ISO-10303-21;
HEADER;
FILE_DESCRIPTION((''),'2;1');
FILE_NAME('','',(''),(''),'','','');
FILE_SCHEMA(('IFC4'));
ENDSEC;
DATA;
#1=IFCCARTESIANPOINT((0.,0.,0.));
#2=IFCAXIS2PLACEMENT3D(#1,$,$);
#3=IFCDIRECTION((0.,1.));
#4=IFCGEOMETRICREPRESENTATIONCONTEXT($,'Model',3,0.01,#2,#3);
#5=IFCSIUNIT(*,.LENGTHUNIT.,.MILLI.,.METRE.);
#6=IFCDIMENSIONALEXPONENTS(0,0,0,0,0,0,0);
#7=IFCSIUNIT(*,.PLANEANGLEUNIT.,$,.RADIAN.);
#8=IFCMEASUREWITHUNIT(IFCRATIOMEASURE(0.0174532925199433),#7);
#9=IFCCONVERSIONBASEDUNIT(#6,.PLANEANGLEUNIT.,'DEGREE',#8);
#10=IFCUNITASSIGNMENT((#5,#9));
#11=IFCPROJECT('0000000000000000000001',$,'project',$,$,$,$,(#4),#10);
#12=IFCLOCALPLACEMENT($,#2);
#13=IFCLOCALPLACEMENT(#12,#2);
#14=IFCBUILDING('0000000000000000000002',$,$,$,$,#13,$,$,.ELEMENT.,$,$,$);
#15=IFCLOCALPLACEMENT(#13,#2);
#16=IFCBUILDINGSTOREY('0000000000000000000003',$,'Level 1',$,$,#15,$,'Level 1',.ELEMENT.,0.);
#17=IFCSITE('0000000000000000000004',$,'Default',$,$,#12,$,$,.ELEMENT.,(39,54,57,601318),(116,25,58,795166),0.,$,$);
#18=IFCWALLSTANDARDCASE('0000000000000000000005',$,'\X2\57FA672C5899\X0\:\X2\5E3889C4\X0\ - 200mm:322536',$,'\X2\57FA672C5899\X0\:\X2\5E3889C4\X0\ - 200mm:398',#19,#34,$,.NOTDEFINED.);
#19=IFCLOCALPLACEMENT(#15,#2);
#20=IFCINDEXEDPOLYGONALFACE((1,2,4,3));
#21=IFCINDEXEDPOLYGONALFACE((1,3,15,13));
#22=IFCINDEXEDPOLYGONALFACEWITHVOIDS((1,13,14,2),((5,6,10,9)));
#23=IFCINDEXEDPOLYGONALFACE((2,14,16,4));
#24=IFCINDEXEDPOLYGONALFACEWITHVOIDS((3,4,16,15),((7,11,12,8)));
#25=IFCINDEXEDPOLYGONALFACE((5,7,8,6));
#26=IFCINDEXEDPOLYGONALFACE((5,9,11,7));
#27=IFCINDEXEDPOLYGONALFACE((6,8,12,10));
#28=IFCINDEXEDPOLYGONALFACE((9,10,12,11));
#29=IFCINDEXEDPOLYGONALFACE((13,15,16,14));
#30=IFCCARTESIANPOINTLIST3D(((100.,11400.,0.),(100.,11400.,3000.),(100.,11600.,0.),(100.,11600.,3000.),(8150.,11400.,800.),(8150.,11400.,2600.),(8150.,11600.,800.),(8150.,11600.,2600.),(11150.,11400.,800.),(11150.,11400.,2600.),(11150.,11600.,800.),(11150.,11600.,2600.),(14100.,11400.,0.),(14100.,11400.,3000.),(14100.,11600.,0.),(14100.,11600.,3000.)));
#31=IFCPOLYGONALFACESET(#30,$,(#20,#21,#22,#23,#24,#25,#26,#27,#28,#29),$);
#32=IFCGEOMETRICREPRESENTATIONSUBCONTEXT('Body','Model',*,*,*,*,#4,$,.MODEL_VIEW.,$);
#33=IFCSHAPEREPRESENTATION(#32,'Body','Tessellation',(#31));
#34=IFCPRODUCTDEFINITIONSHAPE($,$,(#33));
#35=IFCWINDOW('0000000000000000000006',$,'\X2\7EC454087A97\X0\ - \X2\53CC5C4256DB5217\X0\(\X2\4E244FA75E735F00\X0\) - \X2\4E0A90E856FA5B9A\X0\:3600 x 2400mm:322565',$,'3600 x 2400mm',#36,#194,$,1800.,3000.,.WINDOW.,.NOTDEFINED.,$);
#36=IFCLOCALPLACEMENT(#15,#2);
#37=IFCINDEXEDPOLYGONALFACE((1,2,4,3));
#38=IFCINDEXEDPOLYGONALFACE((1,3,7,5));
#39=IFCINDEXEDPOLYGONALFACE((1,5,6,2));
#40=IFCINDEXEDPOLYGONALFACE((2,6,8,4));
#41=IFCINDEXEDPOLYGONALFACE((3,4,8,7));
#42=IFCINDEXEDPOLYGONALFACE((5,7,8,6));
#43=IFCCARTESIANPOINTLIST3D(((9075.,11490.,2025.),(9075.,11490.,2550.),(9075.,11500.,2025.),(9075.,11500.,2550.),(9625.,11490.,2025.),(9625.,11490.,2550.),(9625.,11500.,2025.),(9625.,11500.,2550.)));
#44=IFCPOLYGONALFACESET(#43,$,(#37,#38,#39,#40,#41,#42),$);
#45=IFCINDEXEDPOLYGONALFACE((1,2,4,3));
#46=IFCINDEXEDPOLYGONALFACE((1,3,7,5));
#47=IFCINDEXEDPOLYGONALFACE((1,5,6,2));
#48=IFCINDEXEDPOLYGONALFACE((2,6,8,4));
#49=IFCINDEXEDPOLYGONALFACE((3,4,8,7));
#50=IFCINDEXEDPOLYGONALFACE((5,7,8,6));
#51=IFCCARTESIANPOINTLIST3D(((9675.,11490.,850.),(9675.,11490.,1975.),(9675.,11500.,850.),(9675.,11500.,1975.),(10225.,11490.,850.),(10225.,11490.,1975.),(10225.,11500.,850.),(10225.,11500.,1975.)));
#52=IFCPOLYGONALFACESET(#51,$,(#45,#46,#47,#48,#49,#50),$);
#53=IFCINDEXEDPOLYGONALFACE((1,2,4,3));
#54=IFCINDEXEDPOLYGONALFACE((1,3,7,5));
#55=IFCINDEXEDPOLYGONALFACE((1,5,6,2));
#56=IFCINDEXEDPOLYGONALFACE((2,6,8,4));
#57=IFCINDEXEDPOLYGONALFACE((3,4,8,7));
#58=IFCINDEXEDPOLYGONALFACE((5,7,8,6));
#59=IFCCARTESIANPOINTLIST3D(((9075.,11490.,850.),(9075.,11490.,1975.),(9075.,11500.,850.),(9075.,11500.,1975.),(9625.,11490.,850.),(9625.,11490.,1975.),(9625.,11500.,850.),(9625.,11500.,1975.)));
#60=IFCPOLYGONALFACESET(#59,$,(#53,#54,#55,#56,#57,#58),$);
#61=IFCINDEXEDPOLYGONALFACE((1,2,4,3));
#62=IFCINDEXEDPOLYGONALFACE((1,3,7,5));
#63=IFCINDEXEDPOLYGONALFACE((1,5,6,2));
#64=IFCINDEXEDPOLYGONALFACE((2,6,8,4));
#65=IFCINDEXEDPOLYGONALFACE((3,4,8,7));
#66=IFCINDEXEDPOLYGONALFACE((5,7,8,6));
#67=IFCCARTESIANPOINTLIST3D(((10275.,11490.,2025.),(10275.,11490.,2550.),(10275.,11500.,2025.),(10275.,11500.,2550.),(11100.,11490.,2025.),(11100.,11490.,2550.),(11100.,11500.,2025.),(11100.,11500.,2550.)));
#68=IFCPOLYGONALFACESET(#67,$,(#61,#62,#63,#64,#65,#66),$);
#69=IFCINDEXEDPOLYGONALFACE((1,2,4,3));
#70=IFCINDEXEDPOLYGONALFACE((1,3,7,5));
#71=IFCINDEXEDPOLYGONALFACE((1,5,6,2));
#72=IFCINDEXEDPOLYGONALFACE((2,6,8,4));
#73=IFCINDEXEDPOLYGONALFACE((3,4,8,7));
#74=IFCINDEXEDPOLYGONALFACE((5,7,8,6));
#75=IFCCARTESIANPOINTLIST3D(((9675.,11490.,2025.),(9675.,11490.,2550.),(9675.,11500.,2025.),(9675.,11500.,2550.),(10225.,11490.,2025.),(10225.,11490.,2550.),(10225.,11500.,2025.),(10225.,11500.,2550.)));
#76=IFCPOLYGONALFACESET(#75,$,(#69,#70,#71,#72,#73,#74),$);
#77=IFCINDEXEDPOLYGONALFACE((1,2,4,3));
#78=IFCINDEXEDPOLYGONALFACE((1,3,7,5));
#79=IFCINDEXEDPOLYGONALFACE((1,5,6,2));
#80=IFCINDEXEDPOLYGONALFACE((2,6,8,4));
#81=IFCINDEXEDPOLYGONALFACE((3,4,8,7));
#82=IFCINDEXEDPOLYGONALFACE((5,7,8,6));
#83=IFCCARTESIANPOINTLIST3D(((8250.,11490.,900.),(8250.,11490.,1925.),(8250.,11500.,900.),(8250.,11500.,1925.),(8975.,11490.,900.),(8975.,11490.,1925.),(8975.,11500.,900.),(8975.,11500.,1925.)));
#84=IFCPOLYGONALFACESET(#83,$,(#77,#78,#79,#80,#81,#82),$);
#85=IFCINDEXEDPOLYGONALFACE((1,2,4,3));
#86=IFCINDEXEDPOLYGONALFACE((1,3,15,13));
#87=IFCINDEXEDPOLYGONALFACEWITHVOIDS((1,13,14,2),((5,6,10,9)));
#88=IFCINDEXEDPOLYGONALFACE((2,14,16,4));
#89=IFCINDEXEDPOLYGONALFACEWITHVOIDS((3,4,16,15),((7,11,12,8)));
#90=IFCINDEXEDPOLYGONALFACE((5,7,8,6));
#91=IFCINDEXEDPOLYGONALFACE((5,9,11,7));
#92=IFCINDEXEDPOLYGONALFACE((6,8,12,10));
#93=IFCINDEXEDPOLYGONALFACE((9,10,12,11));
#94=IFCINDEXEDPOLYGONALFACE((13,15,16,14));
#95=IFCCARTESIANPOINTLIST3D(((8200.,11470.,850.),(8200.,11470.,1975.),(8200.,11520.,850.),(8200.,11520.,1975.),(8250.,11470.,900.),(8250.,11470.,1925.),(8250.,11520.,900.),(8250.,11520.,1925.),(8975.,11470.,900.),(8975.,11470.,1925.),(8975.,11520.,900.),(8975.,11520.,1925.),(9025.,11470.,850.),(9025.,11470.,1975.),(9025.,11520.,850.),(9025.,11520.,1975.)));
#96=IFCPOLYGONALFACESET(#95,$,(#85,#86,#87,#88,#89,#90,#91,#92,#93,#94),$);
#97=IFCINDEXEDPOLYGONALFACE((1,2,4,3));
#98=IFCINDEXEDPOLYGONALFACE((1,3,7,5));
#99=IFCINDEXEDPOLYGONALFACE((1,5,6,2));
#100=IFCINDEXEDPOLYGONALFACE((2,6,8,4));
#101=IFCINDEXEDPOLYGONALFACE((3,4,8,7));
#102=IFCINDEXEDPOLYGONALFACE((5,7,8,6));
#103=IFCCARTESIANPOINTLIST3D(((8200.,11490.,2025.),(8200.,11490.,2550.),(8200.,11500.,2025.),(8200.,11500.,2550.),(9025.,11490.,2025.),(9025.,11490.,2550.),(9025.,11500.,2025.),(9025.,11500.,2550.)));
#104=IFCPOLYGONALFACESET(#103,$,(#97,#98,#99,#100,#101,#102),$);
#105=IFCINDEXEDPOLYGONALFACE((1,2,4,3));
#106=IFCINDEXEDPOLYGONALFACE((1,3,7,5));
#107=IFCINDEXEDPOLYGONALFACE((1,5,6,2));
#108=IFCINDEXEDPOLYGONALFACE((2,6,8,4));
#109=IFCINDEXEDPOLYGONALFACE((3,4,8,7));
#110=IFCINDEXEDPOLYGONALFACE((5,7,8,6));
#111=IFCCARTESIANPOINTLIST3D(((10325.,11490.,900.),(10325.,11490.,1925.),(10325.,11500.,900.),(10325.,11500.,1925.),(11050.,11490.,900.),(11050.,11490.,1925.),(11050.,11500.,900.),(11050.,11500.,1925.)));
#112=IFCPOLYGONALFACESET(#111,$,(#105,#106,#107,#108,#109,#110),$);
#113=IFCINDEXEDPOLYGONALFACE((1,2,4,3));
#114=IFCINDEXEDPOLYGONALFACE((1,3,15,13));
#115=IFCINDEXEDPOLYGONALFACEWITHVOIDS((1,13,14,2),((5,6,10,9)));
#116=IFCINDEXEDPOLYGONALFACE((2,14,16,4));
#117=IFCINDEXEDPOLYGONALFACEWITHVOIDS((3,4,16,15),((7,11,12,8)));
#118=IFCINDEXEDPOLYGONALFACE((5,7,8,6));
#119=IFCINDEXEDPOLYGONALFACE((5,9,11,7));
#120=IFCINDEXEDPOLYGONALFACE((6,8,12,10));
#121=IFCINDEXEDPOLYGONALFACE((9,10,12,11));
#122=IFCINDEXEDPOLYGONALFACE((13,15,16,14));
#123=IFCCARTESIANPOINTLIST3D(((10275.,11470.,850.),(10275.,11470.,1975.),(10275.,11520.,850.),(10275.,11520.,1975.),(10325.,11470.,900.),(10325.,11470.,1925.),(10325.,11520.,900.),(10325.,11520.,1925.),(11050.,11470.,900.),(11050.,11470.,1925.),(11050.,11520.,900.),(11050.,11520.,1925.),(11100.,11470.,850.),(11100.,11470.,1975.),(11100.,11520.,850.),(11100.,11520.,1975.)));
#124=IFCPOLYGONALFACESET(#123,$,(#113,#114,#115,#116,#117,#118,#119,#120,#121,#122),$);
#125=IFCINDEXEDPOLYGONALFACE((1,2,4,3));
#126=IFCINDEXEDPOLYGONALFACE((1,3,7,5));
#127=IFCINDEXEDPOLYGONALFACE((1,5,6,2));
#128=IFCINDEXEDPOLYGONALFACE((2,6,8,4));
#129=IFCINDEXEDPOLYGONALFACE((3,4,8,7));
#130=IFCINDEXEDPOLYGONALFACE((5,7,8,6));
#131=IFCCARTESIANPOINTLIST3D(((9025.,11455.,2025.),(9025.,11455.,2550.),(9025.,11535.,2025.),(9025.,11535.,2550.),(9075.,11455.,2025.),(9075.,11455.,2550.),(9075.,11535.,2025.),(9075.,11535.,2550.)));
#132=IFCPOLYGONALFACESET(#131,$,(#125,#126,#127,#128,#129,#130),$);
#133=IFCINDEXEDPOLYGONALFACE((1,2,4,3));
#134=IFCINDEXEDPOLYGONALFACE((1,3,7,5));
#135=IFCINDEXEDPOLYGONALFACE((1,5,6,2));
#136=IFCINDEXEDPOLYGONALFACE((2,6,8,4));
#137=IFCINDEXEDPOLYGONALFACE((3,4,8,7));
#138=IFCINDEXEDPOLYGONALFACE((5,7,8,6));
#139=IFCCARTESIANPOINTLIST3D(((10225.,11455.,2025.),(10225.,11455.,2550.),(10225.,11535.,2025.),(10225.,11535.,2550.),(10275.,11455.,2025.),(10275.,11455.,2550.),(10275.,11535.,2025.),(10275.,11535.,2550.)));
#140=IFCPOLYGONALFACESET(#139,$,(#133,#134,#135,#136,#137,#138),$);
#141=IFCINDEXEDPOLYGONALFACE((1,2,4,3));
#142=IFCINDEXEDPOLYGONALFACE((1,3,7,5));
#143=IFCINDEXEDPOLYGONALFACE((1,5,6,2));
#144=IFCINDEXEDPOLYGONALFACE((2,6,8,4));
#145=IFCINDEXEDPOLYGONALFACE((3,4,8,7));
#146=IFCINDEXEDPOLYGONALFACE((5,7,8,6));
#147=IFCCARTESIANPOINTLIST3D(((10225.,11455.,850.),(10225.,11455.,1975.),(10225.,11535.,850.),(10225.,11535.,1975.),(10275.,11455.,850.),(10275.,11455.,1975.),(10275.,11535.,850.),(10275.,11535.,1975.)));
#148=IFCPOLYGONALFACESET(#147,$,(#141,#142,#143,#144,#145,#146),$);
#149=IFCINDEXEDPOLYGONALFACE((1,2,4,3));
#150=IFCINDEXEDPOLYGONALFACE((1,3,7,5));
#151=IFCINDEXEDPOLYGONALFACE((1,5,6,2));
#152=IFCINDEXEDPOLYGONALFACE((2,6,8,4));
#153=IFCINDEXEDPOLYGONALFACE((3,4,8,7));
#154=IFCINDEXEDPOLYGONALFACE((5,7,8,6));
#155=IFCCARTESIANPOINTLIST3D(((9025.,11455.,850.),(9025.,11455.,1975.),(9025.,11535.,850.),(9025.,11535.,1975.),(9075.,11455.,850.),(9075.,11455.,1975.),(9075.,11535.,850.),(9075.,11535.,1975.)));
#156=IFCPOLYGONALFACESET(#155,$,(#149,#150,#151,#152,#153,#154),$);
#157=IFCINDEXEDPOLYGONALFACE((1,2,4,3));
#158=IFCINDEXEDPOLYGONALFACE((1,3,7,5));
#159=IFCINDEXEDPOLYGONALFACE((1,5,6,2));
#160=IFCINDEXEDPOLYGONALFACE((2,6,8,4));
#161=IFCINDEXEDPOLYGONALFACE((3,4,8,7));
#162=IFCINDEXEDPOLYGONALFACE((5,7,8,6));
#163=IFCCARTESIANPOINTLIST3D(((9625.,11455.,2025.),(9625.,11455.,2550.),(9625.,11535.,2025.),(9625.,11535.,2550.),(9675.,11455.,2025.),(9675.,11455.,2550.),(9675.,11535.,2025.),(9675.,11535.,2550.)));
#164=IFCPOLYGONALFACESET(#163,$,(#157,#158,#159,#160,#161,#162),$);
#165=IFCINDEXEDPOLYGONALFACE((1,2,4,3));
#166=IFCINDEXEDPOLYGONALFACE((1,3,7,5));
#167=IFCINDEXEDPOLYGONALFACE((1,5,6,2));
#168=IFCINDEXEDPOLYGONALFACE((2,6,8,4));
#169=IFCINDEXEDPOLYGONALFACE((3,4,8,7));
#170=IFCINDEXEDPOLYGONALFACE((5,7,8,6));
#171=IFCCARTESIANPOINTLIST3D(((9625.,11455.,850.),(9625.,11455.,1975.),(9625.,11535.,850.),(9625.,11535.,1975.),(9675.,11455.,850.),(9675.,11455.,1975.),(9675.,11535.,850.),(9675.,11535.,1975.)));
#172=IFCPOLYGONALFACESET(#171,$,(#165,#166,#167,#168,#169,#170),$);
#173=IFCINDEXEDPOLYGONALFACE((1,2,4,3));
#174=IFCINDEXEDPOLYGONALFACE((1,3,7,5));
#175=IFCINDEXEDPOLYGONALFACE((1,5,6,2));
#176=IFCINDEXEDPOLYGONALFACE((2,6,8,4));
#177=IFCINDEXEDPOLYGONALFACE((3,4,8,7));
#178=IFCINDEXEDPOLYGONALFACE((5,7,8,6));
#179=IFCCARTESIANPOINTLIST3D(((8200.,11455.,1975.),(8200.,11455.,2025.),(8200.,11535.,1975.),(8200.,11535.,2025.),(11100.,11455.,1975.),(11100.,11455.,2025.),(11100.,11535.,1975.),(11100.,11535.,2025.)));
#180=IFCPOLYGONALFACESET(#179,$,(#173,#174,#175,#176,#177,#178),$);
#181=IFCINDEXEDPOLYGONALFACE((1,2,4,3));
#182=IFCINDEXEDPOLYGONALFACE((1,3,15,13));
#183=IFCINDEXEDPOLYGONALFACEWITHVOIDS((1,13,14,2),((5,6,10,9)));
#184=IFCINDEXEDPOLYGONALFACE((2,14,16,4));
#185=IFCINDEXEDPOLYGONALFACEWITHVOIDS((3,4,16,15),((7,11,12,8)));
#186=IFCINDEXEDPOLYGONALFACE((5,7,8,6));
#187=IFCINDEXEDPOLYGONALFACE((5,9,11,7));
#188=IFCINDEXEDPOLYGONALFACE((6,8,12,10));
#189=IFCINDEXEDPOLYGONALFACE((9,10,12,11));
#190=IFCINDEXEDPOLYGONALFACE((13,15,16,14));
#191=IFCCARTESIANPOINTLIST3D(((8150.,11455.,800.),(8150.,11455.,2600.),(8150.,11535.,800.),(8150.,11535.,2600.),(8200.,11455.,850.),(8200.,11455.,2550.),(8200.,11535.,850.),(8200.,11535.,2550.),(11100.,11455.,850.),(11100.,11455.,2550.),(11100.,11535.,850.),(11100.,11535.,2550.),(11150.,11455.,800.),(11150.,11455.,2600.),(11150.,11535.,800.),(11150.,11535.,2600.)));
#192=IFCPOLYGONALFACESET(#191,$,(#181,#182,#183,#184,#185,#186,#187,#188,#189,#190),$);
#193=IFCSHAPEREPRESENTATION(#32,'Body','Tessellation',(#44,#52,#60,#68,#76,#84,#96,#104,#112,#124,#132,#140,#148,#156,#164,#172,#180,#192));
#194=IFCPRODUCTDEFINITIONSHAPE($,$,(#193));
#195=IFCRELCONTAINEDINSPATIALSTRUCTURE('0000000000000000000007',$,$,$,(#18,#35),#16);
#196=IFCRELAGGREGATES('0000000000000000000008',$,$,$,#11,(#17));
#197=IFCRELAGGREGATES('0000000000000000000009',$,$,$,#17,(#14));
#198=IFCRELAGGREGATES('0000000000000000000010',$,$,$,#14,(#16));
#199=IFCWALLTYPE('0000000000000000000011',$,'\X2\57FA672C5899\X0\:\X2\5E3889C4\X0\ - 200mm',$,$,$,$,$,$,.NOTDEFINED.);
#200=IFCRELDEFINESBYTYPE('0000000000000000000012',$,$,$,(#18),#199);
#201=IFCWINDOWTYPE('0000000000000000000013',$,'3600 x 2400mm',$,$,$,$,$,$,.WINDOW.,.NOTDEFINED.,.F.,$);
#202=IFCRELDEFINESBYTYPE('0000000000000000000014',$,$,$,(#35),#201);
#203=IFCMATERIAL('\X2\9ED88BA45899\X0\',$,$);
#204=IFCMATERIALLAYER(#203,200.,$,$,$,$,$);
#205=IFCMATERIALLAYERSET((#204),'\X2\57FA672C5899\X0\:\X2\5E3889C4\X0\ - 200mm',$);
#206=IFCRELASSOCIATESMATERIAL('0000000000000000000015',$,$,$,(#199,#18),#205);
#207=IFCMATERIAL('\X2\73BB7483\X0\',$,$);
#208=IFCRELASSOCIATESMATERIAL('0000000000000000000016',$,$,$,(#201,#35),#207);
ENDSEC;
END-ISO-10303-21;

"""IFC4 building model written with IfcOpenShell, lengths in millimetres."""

from ifc_helpers import new_model, entity, si_unit, converted_unit, direction, frame, frame_2d, origin, origin_2d_with_axis, place, context, subcontext, project, spatial, polyline, rectangle, outline, extrude, source, transform, mapped, material, layer, layer_set, layer_usage, type_object, type_shapes, element, fill, save


model = new_model("IFC4")

# Units and contexts
model_context_1 = context("Model", 3, precision=0.01, world=origin(), true_north=direction((0.0, 1.0)))
body_context_1 = subcontext(model_context_1, "Body", "Model", "MODEL_VIEW")
ifc_project = project(units=[si_unit("LENGTHUNIT", "METRE", prefix="MILLI"), converted_unit("PLANEANGLEUNIT", "DEGREE", entity("IfcRatioMeasure", 0.0174532925199433), si_unit("PLANEANGLEUNIT", "RADIAN"), dimensions=[0, 0, 0, 0, 0, 0, 0])], contexts=[model_context_1])

# Site, building, storey
site_placement = place(None, origin())
site = spatial("IfcSite", under=ifc_project, at=site_placement, Name="Default", CompositionType="ELEMENT", RefLatitude=(39, 54, 57, 601318), RefLongitude=(116, 25, 58, 795166), RefElevation=0.0)
building_placement = place(site_placement, origin())
building = spatial("IfcBuilding", under=site, at=building_placement, CompositionType="ELEMENT")
storey_placement = place(building_placement, origin())
storey = spatial("IfcBuildingStorey", under=building, at=storey_placement, Name="Level 1", LongName="Level 1", CompositionType="ELEMENT", Elevation=0.0)

# Shared definitions
ifc_material_1 = material(Name="默认墙")
ifc_layer_1 = layer(ifc_material_1, 200.0)
ifc_layer_set_1 = layer_set([ifc_layer_1], Name="基本墙:常规 - 200mm")
wall_type = type_object("IfcWallType", Name="基本墙:常规 - 200mm", PredefinedType="NOTDEFINED", material=ifc_layer_set_1)
ifc_material_2 = material(Name="玻璃")

# Wall, opening, window
ifc_layer_usage_1 = layer_usage(ifc_layer_set_1, "AXIS2", "NEGATIVE", 100.0)
wall_1_placement = place(storey_placement, frame((100.0, 11500.0, 0.0)))
wall_1 = element("IfcWallStandardCase", 1, at=wall_1_placement, inside=storey, type_object=wall_type, material=ifc_layer_usage_1, Name="基本墙:常规 - 200mm:322536", ObjectType="基本墙:常规 - 200mm:398", PredefinedType="NOTDEFINED", context=body_context_1, shape_type="SweptSolid", body=[
    extrude(rectangle(XDim=14000.0, YDim=200.0, at=frame_2d((7000.0, 0.0), x_axis=(-1.0, 0.0))), origin(), (0.0, 0.0, 1.0), 3000.0),
])
opening_1_placement = place(wall_1_placement, frame((8050.0, -100.0, 800.0)))
opening_1 = element("IfcOpeningElement", 2, at=opening_1_placement, cuts=wall_1, ObjectType="Opening", PredefinedType="OPENING", context=body_context_1, shape_type="SweptSolid", body=[
    extrude(rectangle(XDim=1800.0, YDim=3000.0, at=frame_2d((900.0, 1500.0), x_axis=(1.0, 0.0))), frame((0.0, 0.0, 0.0), z_axis=(0.0, 1.0, 0.0), x_axis=(0.0, 0.0, 1.0)), (0.0, 0.0, 1.0), 200.0),
])
window_type_1 = type_object("IfcWindowType", Name="3600 x 2400mm", ParameterTakesPrecedence=False, PartitioningType="NOTDEFINED", PredefinedType="WINDOW", material=ifc_material_2)
shared_shape_1 = source(origin(), body_context_1, "Body", "SweptSolid", [
    extrude(rectangle(XDim=10.0, YDim=550.0, at=origin_2d_with_axis()), frame((1200.0, 95.0, 1225.0), z_axis=(0.0, 0.0, 1.0), x_axis=(0.0, 1.0, 0.0)), (0.0, 0.0, 1.0), 525.0),
    extrude(rectangle(XDim=10.0, YDim=550.0, at=origin_2d_with_axis()), frame((1800.0, 95.0, 50.0), z_axis=(0.0, 0.0, 1.0), x_axis=(0.0, 1.0, 0.0)), (0.0, 0.0, 1.0), 1125.0),
    extrude(rectangle(XDim=10.0, YDim=550.0, at=origin_2d_with_axis()), frame((1200.0, 95.0, 50.0), z_axis=(0.0, 0.0, 1.0), x_axis=(0.0, 1.0, 0.0)), (0.0, 0.0, 1.0), 1125.0),
    extrude(rectangle(XDim=10.0, YDim=825.0, at=frame_2d((0.0, 0.0), x_axis=(1.0, 0.0))), frame((2537.5, 95.0, 1225.0), z_axis=(0.0, 0.0, 1.0), x_axis=(0.0, 1.0, 0.0)), (0.0, 0.0, 1.0), 525.0),
    extrude(rectangle(XDim=10.0, YDim=550.0, at=frame_2d((0.0, 0.0), x_axis=(1.0, 0.0))), frame((1800.0, 95.0, 1225.0), z_axis=(0.0, 0.0, 1.0), x_axis=(0.0, 1.0, 0.0)), (0.0, 0.0, 1.0), 525.0),
    extrude(rectangle(XDim=10.0, YDim=725.0, at=frame_2d((0.0, 0.0), x_axis=(1.0, 0.0))), frame((462.5, 95.0, 100.0), z_axis=(0.0, 0.0, 1.0), x_axis=(0.0, 1.0, 0.0)), (0.0, 0.0, 1.0), 1025.0),
    extrude(outline(polyline([(-562.5, -412.5), (562.5, -412.5), (562.5, 412.5), (-562.5, 412.5), (-562.5, -412.5)]), holes=[polyline([(512.5, -362.5), (-512.5, -362.5), (-512.5, 362.5), (512.5, 362.5), (512.5, -362.5)])]), frame((462.5, 70.0, 612.5), z_axis=(0.0, 1.0, 0.0), x_axis=(0.0, 0.0, -1.0)), (0.0, 0.0, 1.0), 50.0),
    extrude(rectangle(XDim=10.0, YDim=825.0, at=origin_2d_with_axis()), frame((462.5, 95.0, 1225.0), z_axis=(0.0, 0.0, 1.0), x_axis=(0.0, 1.0, 0.0)), (0.0, 0.0, 1.0), 525.0),
    extrude(rectangle(XDim=10.0, YDim=725.0, at=frame_2d((0.0, 0.0), x_axis=(1.0, 0.0))), frame((2537.5, 95.0, 100.0), z_axis=(0.0, 0.0, 1.0), x_axis=(0.0, 1.0, 0.0)), (0.0, 0.0, 1.0), 1025.0),
    extrude(outline(polyline([(-562.5, -412.5), (562.5, -412.5), (562.5, 412.5), (-562.5, 412.5), (-562.5, -412.5)]), holes=[polyline([(512.5, -362.5), (-512.5, -362.5), (-512.5, 362.5), (512.5, 362.5), (512.5, -362.5)])]), frame((2537.5, 70.0, 612.5), z_axis=(0.0, 1.0, 0.0), x_axis=(0.0, 0.0, -1.0)), (0.0, 0.0, 1.0), 50.0),
    extrude(rectangle(XDim=80.0, YDim=50.0, at=origin_2d_with_axis()), frame((900.0, 95.0, 1225.0), z_axis=(0.0, 0.0, 1.0), x_axis=(0.0, -1.0, 0.0)), (0.0, 0.0, 1.0), 525.0),
    extrude(rectangle(XDim=80.0, YDim=50.0, at=frame_2d((0.0, 0.0), x_axis=(1.0, 0.0))), frame((2100.0, 95.0, 1225.0), z_axis=(0.0, 0.0, 1.0), x_axis=(0.0, -1.0, 0.0)), (0.0, 0.0, 1.0), 525.0),
    extrude(rectangle(XDim=80.0, YDim=50.0, at=origin_2d_with_axis()), frame((2100.0, 95.0, 50.0), z_axis=(0.0, 0.0, 1.0), x_axis=(0.0, -1.0, 0.0)), (0.0, 0.0, 1.0), 1125.0),
    extrude(rectangle(XDim=80.0, YDim=50.0, at=origin_2d_with_axis()), frame((900.0, 95.0, 50.0), z_axis=(0.0, 0.0, 1.0), x_axis=(0.0, -1.0, 0.0)), (0.0, 0.0, 1.0), 1125.0),
    extrude(rectangle(XDim=80.0, YDim=50.0, at=frame_2d((0.0, 0.0), x_axis=(1.0, 0.0))), frame((1500.0, 95.0, 1225.0), z_axis=(0.0, 0.0, 1.0), x_axis=(0.0, -1.0, 0.0)), (0.0, 0.0, 1.0), 525.0),
    extrude(rectangle(XDim=80.0, YDim=50.0, at=origin_2d_with_axis()), frame((1500.0, 95.0, 50.0), z_axis=(0.0, 0.0, 1.0), x_axis=(0.0, -1.0, 0.0)), (0.0, 0.0, 1.0), 1125.0),
    extrude(rectangle(XDim=80.0, YDim=2900.0, at=frame_2d((0.0, 0.0), x_axis=(1.0, 0.0))), frame((1500.0, 95.0, 1175.0), z_axis=(0.0, 0.0, 1.0), x_axis=(0.0, -1.0, 0.0)), (0.0, 0.0, 1.0), 50.0),
    extrude(outline(polyline([(-1500.0, -900.0), (1500.0, -900.0), (1500.0, 900.0), (-1500.0, 900.0), (-1500.0, -900.0)]), holes=[polyline([(1450.0, -850.0), (-1450.0, -850.0), (-1450.0, 850.0), (1450.0, 850.0), (1450.0, -850.0)])]), frame((1500.0, 55.0, 900.0), z_axis=(0.0, 1.0, 0.0), x_axis=(1.0, 0.0, 0.0)), (0.0, 0.0, 1.0), 80.0),
])
type_shapes(window_type_1, [shared_shape_1])
window_1_placement = place(opening_1_placement, origin())
window_1 = element("IfcWindow", 3, at=window_1_placement, inside=storey, type_object=window_type_1, material=ifc_material_2, Name="组合窗 - 双层四列(两侧平开) - 上部固定:3600 x 2400mm:322565", ObjectType="3600 x 2400mm", OverallHeight=1800.0, OverallWidth=3000.0, PartitioningType="NOTDEFINED", PredefinedType="WINDOW", context=body_context_1, shape_type="MappedRepresentation", body=[
    mapped(shared_shape_1, transform((0.0, 0.0, 0.0), scale=1.0)),
])
fill(opening_1, window_1)

save(model, "model.ifc")
